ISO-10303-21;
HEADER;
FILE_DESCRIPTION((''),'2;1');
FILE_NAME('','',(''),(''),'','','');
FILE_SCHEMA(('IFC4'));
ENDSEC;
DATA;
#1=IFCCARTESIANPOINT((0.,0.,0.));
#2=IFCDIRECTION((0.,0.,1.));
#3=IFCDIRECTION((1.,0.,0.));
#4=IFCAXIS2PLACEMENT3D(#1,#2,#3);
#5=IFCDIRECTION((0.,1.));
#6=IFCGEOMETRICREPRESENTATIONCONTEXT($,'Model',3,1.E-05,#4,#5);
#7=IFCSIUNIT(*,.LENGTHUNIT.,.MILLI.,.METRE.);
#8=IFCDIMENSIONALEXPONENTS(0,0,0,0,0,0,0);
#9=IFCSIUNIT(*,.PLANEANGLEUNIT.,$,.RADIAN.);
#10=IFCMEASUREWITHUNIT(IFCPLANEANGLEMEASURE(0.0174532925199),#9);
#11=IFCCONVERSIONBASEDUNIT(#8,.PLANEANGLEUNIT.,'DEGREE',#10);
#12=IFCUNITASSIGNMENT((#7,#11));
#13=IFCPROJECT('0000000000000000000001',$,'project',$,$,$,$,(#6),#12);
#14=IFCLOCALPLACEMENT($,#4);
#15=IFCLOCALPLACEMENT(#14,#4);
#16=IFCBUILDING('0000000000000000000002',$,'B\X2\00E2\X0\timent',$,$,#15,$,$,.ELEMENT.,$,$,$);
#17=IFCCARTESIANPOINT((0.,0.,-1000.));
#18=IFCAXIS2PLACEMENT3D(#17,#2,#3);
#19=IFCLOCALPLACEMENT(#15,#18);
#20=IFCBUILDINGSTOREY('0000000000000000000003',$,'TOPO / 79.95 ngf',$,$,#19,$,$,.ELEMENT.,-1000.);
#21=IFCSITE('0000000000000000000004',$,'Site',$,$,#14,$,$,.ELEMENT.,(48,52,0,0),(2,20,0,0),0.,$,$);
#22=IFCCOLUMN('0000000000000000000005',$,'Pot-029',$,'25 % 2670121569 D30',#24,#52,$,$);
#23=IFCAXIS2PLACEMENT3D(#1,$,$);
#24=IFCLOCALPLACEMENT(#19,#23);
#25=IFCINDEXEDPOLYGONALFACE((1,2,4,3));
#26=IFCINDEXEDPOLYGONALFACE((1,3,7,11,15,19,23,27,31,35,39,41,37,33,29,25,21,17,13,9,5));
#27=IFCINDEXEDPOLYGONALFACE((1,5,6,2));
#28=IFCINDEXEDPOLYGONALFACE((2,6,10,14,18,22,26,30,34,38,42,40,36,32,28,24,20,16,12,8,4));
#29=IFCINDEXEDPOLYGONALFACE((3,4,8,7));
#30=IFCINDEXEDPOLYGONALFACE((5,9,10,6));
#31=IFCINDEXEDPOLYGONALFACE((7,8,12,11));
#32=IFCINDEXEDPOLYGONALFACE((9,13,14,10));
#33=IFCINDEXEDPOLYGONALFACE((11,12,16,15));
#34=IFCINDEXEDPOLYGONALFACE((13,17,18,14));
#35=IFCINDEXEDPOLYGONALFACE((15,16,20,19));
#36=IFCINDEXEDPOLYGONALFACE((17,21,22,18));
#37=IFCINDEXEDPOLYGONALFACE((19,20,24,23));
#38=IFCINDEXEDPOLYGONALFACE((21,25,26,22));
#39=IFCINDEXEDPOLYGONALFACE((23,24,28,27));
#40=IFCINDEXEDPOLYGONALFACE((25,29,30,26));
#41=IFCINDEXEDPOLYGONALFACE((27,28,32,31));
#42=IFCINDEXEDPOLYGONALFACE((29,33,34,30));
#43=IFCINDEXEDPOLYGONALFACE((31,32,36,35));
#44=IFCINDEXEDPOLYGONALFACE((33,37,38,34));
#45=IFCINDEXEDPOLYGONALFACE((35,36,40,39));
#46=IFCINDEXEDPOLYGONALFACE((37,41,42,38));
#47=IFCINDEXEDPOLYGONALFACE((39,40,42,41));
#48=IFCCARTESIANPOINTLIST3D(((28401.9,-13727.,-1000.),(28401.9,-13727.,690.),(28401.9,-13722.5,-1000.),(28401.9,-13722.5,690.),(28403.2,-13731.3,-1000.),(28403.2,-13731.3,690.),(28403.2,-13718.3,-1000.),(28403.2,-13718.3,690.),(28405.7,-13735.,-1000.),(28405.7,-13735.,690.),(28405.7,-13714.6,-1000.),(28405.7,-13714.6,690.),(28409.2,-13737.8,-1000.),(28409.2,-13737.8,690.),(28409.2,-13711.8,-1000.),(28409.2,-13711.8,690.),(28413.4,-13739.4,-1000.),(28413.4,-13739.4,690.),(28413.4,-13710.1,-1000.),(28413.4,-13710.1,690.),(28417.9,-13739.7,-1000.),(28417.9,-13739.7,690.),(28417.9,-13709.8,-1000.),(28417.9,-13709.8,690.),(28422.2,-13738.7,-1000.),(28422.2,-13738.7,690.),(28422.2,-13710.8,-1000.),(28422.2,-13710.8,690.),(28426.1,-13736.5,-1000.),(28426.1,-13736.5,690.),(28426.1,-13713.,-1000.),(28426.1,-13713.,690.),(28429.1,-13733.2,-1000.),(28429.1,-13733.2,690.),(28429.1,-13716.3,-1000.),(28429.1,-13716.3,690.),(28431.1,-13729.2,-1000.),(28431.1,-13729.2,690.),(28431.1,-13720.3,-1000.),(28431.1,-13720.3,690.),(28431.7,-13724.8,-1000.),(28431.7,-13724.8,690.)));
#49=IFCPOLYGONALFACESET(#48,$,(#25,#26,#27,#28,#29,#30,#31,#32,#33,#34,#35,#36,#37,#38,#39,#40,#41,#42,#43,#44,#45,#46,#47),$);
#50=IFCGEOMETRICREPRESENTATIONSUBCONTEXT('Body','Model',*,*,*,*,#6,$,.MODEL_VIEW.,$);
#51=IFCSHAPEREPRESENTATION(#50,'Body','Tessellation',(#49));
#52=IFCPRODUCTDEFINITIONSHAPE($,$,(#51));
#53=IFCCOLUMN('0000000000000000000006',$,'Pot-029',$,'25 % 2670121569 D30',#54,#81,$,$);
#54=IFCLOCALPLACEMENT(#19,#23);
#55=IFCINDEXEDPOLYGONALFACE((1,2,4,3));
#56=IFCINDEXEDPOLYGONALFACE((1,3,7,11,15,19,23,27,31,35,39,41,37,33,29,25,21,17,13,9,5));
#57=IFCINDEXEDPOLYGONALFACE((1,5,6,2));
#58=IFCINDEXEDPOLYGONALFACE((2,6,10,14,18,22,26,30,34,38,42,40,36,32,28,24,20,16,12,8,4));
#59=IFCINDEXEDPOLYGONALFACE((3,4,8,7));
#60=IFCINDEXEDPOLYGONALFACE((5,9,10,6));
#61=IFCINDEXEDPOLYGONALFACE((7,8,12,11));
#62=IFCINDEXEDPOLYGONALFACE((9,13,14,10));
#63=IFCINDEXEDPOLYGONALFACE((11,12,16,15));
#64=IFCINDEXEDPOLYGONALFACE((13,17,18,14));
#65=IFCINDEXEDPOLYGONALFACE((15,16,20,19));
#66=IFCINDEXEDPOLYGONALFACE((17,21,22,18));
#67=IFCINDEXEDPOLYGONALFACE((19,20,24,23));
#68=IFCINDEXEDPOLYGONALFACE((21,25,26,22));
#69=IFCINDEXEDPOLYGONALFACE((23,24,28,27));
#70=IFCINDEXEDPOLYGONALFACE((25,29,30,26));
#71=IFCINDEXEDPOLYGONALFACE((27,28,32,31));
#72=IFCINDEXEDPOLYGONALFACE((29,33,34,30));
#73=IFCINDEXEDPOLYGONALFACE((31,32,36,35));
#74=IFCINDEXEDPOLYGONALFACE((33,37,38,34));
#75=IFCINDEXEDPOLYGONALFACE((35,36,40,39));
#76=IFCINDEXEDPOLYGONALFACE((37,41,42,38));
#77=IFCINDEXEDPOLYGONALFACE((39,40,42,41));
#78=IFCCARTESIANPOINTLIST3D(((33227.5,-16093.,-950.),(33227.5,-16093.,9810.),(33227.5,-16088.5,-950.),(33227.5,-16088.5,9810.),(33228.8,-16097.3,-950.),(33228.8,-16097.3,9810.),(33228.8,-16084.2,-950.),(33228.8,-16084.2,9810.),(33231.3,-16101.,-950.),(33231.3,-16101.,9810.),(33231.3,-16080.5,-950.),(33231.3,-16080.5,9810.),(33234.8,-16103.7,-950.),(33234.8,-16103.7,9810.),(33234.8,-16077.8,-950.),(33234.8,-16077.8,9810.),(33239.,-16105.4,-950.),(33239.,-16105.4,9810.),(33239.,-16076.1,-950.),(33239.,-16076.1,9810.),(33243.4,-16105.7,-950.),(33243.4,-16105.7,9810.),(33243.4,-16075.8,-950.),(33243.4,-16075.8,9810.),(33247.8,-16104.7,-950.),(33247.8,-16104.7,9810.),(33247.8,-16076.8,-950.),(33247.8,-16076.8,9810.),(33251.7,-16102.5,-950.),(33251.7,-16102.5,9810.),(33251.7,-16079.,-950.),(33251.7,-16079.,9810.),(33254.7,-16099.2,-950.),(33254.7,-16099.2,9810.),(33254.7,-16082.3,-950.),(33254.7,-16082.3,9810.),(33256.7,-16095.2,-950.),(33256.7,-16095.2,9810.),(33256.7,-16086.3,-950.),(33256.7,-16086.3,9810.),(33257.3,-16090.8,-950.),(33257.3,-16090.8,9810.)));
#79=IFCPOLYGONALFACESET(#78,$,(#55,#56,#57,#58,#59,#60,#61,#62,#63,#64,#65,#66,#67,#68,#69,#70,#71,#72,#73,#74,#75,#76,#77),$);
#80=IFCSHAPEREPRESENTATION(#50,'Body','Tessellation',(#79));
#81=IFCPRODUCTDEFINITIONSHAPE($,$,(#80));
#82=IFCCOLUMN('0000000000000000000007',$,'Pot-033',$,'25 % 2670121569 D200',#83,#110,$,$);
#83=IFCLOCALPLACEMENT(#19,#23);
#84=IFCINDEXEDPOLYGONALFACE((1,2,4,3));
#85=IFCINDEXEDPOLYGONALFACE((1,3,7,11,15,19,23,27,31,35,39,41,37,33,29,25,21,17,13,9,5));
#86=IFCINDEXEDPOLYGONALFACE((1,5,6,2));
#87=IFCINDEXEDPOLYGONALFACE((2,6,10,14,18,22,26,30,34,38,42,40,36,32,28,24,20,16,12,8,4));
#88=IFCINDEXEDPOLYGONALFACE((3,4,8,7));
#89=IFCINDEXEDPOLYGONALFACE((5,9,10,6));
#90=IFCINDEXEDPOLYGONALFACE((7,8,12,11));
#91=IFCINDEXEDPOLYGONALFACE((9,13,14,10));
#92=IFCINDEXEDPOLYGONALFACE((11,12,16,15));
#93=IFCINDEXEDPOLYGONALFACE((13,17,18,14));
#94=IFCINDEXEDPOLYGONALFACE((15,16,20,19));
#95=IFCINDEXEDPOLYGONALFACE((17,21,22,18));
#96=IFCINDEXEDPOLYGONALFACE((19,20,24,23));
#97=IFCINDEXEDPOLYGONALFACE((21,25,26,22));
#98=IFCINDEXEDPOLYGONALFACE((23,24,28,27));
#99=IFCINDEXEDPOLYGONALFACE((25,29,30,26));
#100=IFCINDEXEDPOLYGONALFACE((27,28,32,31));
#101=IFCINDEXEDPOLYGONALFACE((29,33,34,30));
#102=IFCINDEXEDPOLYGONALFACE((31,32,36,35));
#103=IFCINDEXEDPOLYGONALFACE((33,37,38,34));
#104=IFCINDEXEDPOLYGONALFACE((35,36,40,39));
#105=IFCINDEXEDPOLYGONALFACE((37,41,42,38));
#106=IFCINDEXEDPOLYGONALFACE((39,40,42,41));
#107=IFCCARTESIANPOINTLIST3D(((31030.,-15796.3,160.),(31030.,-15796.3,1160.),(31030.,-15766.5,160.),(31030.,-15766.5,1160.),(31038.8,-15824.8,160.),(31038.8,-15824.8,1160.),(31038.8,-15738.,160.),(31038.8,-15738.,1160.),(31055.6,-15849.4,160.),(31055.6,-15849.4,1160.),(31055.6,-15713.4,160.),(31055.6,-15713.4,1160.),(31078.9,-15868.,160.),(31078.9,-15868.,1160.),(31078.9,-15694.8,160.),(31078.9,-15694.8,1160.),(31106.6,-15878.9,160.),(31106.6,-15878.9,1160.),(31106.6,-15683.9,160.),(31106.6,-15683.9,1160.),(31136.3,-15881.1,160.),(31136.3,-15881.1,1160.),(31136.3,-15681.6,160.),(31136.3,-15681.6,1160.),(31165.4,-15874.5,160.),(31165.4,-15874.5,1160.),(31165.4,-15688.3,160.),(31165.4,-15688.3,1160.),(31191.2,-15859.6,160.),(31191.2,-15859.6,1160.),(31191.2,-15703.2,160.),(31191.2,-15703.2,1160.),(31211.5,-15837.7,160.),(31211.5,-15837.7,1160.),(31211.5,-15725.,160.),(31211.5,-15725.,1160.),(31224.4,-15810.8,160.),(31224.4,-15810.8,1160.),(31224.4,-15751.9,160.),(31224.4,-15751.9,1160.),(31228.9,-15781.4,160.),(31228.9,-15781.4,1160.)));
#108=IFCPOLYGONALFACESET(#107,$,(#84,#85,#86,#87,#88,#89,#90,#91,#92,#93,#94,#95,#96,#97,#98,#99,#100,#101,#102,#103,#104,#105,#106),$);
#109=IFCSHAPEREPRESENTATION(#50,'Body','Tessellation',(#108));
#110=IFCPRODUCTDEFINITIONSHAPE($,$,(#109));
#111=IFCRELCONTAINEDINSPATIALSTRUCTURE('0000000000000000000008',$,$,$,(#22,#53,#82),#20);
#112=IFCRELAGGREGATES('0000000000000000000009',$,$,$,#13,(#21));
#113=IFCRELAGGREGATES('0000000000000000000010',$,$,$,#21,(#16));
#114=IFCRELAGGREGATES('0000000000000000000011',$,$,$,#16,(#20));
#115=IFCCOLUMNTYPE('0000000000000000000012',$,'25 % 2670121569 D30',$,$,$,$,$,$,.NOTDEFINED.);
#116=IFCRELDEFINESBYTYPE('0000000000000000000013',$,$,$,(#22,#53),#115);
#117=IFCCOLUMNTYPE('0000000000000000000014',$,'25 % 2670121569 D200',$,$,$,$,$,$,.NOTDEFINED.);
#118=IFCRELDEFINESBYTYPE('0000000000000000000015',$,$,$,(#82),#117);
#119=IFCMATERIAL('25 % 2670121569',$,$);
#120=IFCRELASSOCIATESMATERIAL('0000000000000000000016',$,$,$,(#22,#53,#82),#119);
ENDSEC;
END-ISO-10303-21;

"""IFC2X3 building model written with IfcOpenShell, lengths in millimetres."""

from ifc_helpers import new_model, entity, si_unit, converted_unit, direction, frame, origin_with_axes, origin_2d_with_axis, place, context, subcontext, project, spatial, circle, extrude, material, type_object, element, save


model = new_model("IFC2X3")

# Units and contexts
model_context = context("Model", 3, precision=1e-05, world=origin_with_axes(), true_north=direction((0.0, 1.0)))
body_context = subcontext(model_context, "Body", "Model", "MODEL_VIEW")
ifc_project = project(units=[si_unit("LENGTHUNIT", "METRE", prefix="MILLI"), converted_unit("PLANEANGLEUNIT", "DEGREE", entity("IfcPlaneAngleMeasure", 0.0174532925199), si_unit("PLANEANGLEUNIT", "RADIAN"), dimensions=[0, 0, 0, 0, 0, 0, 0])], contexts=[model_context])

# Site, building, storey
site_placement = place(None, origin_with_axes())
site = spatial("IfcSite", under=ifc_project, at=site_placement, Name="Site", CompositionType="ELEMENT", RefLatitude=(48, 52, 0, 0), RefLongitude=(2, 20, 0, 0), RefElevation=0.0)
building_placement = place(site_placement, origin_with_axes())
building = spatial("IfcBuilding", under=site, at=building_placement, Name="Bâtiment", CompositionType="ELEMENT")
storey_placement = place(building_placement, frame((0.0, 0.0, -1000.0), z_axis=(0.0, 0.0, 1.0), x_axis=(1.0, 0.0, 0.0)))
storey = spatial("IfcBuildingStorey", under=building, at=storey_placement, Name="TOPO / 79.95 ngf", CompositionType="ELEMENT", Elevation=-1000.0)

# Columns
ifc_material_1 = material(Name="25 % 2670121569")
column_type_1 = type_object("IfcColumnType", Name="25 % 2670121569 D30", PredefinedType="NOTDEFINED")
column_1_placement = place(storey_placement, frame((28416.7, -13724.8, -1000.0), z_axis=(0.0, 0.0, 1.0), x_axis=(1.0, 0.0, 0.0)))
element("IfcColumn", 1, at=column_1_placement, inside=storey, type_object=column_type_1, material=ifc_material_1, Name="Pot-029", ObjectType="25 % 2670121569 D30", context=body_context, shape_type="SweptSolid", body=[
    extrude(circle(Radius=15.0, at=origin_2d_with_axis()), origin_with_axes(), (0.0, 0.0, 1.0), 1690.0),
])
column_2_placement = place(storey_placement, frame((33242.3, -16090.8, -950.0), z_axis=(0.0, 0.0, 1.0), x_axis=(1.0, 0.0, 0.0)))
element("IfcColumn", 2, at=column_2_placement, inside=storey, type_object=column_type_1, material=ifc_material_1, Name="Pot-029", ObjectType="25 % 2670121569 D30", context=body_context, shape_type="SweptSolid", body=[
    extrude(circle(Radius=15.0, at=origin_2d_with_axis()), origin_with_axes(), (0.0, 0.0, 1.0), 10760.0),
])
column_type_2 = type_object("IfcColumnType", Name="25 % 2670121569 D200", PredefinedType="NOTDEFINED")
column_3_placement = place(storey_placement, frame((31128.9, -15781.4, 160.0), z_axis=(0.0, 0.0, 1.0), x_axis=(1.0, 0.0, 0.0)))
element("IfcColumn", 3, at=column_3_placement, inside=storey, type_object=column_type_2, material=ifc_material_1, Name="Pot-033", ObjectType="25 % 2670121569 D200", context=body_context, shape_type="SweptSolid", body=[
    extrude(circle(Radius=100.0, at=origin_2d_with_axis()), origin_with_axes(), (0.0, 0.0, 1.0), 1000.0),
])

save(model, "model.ifc")
